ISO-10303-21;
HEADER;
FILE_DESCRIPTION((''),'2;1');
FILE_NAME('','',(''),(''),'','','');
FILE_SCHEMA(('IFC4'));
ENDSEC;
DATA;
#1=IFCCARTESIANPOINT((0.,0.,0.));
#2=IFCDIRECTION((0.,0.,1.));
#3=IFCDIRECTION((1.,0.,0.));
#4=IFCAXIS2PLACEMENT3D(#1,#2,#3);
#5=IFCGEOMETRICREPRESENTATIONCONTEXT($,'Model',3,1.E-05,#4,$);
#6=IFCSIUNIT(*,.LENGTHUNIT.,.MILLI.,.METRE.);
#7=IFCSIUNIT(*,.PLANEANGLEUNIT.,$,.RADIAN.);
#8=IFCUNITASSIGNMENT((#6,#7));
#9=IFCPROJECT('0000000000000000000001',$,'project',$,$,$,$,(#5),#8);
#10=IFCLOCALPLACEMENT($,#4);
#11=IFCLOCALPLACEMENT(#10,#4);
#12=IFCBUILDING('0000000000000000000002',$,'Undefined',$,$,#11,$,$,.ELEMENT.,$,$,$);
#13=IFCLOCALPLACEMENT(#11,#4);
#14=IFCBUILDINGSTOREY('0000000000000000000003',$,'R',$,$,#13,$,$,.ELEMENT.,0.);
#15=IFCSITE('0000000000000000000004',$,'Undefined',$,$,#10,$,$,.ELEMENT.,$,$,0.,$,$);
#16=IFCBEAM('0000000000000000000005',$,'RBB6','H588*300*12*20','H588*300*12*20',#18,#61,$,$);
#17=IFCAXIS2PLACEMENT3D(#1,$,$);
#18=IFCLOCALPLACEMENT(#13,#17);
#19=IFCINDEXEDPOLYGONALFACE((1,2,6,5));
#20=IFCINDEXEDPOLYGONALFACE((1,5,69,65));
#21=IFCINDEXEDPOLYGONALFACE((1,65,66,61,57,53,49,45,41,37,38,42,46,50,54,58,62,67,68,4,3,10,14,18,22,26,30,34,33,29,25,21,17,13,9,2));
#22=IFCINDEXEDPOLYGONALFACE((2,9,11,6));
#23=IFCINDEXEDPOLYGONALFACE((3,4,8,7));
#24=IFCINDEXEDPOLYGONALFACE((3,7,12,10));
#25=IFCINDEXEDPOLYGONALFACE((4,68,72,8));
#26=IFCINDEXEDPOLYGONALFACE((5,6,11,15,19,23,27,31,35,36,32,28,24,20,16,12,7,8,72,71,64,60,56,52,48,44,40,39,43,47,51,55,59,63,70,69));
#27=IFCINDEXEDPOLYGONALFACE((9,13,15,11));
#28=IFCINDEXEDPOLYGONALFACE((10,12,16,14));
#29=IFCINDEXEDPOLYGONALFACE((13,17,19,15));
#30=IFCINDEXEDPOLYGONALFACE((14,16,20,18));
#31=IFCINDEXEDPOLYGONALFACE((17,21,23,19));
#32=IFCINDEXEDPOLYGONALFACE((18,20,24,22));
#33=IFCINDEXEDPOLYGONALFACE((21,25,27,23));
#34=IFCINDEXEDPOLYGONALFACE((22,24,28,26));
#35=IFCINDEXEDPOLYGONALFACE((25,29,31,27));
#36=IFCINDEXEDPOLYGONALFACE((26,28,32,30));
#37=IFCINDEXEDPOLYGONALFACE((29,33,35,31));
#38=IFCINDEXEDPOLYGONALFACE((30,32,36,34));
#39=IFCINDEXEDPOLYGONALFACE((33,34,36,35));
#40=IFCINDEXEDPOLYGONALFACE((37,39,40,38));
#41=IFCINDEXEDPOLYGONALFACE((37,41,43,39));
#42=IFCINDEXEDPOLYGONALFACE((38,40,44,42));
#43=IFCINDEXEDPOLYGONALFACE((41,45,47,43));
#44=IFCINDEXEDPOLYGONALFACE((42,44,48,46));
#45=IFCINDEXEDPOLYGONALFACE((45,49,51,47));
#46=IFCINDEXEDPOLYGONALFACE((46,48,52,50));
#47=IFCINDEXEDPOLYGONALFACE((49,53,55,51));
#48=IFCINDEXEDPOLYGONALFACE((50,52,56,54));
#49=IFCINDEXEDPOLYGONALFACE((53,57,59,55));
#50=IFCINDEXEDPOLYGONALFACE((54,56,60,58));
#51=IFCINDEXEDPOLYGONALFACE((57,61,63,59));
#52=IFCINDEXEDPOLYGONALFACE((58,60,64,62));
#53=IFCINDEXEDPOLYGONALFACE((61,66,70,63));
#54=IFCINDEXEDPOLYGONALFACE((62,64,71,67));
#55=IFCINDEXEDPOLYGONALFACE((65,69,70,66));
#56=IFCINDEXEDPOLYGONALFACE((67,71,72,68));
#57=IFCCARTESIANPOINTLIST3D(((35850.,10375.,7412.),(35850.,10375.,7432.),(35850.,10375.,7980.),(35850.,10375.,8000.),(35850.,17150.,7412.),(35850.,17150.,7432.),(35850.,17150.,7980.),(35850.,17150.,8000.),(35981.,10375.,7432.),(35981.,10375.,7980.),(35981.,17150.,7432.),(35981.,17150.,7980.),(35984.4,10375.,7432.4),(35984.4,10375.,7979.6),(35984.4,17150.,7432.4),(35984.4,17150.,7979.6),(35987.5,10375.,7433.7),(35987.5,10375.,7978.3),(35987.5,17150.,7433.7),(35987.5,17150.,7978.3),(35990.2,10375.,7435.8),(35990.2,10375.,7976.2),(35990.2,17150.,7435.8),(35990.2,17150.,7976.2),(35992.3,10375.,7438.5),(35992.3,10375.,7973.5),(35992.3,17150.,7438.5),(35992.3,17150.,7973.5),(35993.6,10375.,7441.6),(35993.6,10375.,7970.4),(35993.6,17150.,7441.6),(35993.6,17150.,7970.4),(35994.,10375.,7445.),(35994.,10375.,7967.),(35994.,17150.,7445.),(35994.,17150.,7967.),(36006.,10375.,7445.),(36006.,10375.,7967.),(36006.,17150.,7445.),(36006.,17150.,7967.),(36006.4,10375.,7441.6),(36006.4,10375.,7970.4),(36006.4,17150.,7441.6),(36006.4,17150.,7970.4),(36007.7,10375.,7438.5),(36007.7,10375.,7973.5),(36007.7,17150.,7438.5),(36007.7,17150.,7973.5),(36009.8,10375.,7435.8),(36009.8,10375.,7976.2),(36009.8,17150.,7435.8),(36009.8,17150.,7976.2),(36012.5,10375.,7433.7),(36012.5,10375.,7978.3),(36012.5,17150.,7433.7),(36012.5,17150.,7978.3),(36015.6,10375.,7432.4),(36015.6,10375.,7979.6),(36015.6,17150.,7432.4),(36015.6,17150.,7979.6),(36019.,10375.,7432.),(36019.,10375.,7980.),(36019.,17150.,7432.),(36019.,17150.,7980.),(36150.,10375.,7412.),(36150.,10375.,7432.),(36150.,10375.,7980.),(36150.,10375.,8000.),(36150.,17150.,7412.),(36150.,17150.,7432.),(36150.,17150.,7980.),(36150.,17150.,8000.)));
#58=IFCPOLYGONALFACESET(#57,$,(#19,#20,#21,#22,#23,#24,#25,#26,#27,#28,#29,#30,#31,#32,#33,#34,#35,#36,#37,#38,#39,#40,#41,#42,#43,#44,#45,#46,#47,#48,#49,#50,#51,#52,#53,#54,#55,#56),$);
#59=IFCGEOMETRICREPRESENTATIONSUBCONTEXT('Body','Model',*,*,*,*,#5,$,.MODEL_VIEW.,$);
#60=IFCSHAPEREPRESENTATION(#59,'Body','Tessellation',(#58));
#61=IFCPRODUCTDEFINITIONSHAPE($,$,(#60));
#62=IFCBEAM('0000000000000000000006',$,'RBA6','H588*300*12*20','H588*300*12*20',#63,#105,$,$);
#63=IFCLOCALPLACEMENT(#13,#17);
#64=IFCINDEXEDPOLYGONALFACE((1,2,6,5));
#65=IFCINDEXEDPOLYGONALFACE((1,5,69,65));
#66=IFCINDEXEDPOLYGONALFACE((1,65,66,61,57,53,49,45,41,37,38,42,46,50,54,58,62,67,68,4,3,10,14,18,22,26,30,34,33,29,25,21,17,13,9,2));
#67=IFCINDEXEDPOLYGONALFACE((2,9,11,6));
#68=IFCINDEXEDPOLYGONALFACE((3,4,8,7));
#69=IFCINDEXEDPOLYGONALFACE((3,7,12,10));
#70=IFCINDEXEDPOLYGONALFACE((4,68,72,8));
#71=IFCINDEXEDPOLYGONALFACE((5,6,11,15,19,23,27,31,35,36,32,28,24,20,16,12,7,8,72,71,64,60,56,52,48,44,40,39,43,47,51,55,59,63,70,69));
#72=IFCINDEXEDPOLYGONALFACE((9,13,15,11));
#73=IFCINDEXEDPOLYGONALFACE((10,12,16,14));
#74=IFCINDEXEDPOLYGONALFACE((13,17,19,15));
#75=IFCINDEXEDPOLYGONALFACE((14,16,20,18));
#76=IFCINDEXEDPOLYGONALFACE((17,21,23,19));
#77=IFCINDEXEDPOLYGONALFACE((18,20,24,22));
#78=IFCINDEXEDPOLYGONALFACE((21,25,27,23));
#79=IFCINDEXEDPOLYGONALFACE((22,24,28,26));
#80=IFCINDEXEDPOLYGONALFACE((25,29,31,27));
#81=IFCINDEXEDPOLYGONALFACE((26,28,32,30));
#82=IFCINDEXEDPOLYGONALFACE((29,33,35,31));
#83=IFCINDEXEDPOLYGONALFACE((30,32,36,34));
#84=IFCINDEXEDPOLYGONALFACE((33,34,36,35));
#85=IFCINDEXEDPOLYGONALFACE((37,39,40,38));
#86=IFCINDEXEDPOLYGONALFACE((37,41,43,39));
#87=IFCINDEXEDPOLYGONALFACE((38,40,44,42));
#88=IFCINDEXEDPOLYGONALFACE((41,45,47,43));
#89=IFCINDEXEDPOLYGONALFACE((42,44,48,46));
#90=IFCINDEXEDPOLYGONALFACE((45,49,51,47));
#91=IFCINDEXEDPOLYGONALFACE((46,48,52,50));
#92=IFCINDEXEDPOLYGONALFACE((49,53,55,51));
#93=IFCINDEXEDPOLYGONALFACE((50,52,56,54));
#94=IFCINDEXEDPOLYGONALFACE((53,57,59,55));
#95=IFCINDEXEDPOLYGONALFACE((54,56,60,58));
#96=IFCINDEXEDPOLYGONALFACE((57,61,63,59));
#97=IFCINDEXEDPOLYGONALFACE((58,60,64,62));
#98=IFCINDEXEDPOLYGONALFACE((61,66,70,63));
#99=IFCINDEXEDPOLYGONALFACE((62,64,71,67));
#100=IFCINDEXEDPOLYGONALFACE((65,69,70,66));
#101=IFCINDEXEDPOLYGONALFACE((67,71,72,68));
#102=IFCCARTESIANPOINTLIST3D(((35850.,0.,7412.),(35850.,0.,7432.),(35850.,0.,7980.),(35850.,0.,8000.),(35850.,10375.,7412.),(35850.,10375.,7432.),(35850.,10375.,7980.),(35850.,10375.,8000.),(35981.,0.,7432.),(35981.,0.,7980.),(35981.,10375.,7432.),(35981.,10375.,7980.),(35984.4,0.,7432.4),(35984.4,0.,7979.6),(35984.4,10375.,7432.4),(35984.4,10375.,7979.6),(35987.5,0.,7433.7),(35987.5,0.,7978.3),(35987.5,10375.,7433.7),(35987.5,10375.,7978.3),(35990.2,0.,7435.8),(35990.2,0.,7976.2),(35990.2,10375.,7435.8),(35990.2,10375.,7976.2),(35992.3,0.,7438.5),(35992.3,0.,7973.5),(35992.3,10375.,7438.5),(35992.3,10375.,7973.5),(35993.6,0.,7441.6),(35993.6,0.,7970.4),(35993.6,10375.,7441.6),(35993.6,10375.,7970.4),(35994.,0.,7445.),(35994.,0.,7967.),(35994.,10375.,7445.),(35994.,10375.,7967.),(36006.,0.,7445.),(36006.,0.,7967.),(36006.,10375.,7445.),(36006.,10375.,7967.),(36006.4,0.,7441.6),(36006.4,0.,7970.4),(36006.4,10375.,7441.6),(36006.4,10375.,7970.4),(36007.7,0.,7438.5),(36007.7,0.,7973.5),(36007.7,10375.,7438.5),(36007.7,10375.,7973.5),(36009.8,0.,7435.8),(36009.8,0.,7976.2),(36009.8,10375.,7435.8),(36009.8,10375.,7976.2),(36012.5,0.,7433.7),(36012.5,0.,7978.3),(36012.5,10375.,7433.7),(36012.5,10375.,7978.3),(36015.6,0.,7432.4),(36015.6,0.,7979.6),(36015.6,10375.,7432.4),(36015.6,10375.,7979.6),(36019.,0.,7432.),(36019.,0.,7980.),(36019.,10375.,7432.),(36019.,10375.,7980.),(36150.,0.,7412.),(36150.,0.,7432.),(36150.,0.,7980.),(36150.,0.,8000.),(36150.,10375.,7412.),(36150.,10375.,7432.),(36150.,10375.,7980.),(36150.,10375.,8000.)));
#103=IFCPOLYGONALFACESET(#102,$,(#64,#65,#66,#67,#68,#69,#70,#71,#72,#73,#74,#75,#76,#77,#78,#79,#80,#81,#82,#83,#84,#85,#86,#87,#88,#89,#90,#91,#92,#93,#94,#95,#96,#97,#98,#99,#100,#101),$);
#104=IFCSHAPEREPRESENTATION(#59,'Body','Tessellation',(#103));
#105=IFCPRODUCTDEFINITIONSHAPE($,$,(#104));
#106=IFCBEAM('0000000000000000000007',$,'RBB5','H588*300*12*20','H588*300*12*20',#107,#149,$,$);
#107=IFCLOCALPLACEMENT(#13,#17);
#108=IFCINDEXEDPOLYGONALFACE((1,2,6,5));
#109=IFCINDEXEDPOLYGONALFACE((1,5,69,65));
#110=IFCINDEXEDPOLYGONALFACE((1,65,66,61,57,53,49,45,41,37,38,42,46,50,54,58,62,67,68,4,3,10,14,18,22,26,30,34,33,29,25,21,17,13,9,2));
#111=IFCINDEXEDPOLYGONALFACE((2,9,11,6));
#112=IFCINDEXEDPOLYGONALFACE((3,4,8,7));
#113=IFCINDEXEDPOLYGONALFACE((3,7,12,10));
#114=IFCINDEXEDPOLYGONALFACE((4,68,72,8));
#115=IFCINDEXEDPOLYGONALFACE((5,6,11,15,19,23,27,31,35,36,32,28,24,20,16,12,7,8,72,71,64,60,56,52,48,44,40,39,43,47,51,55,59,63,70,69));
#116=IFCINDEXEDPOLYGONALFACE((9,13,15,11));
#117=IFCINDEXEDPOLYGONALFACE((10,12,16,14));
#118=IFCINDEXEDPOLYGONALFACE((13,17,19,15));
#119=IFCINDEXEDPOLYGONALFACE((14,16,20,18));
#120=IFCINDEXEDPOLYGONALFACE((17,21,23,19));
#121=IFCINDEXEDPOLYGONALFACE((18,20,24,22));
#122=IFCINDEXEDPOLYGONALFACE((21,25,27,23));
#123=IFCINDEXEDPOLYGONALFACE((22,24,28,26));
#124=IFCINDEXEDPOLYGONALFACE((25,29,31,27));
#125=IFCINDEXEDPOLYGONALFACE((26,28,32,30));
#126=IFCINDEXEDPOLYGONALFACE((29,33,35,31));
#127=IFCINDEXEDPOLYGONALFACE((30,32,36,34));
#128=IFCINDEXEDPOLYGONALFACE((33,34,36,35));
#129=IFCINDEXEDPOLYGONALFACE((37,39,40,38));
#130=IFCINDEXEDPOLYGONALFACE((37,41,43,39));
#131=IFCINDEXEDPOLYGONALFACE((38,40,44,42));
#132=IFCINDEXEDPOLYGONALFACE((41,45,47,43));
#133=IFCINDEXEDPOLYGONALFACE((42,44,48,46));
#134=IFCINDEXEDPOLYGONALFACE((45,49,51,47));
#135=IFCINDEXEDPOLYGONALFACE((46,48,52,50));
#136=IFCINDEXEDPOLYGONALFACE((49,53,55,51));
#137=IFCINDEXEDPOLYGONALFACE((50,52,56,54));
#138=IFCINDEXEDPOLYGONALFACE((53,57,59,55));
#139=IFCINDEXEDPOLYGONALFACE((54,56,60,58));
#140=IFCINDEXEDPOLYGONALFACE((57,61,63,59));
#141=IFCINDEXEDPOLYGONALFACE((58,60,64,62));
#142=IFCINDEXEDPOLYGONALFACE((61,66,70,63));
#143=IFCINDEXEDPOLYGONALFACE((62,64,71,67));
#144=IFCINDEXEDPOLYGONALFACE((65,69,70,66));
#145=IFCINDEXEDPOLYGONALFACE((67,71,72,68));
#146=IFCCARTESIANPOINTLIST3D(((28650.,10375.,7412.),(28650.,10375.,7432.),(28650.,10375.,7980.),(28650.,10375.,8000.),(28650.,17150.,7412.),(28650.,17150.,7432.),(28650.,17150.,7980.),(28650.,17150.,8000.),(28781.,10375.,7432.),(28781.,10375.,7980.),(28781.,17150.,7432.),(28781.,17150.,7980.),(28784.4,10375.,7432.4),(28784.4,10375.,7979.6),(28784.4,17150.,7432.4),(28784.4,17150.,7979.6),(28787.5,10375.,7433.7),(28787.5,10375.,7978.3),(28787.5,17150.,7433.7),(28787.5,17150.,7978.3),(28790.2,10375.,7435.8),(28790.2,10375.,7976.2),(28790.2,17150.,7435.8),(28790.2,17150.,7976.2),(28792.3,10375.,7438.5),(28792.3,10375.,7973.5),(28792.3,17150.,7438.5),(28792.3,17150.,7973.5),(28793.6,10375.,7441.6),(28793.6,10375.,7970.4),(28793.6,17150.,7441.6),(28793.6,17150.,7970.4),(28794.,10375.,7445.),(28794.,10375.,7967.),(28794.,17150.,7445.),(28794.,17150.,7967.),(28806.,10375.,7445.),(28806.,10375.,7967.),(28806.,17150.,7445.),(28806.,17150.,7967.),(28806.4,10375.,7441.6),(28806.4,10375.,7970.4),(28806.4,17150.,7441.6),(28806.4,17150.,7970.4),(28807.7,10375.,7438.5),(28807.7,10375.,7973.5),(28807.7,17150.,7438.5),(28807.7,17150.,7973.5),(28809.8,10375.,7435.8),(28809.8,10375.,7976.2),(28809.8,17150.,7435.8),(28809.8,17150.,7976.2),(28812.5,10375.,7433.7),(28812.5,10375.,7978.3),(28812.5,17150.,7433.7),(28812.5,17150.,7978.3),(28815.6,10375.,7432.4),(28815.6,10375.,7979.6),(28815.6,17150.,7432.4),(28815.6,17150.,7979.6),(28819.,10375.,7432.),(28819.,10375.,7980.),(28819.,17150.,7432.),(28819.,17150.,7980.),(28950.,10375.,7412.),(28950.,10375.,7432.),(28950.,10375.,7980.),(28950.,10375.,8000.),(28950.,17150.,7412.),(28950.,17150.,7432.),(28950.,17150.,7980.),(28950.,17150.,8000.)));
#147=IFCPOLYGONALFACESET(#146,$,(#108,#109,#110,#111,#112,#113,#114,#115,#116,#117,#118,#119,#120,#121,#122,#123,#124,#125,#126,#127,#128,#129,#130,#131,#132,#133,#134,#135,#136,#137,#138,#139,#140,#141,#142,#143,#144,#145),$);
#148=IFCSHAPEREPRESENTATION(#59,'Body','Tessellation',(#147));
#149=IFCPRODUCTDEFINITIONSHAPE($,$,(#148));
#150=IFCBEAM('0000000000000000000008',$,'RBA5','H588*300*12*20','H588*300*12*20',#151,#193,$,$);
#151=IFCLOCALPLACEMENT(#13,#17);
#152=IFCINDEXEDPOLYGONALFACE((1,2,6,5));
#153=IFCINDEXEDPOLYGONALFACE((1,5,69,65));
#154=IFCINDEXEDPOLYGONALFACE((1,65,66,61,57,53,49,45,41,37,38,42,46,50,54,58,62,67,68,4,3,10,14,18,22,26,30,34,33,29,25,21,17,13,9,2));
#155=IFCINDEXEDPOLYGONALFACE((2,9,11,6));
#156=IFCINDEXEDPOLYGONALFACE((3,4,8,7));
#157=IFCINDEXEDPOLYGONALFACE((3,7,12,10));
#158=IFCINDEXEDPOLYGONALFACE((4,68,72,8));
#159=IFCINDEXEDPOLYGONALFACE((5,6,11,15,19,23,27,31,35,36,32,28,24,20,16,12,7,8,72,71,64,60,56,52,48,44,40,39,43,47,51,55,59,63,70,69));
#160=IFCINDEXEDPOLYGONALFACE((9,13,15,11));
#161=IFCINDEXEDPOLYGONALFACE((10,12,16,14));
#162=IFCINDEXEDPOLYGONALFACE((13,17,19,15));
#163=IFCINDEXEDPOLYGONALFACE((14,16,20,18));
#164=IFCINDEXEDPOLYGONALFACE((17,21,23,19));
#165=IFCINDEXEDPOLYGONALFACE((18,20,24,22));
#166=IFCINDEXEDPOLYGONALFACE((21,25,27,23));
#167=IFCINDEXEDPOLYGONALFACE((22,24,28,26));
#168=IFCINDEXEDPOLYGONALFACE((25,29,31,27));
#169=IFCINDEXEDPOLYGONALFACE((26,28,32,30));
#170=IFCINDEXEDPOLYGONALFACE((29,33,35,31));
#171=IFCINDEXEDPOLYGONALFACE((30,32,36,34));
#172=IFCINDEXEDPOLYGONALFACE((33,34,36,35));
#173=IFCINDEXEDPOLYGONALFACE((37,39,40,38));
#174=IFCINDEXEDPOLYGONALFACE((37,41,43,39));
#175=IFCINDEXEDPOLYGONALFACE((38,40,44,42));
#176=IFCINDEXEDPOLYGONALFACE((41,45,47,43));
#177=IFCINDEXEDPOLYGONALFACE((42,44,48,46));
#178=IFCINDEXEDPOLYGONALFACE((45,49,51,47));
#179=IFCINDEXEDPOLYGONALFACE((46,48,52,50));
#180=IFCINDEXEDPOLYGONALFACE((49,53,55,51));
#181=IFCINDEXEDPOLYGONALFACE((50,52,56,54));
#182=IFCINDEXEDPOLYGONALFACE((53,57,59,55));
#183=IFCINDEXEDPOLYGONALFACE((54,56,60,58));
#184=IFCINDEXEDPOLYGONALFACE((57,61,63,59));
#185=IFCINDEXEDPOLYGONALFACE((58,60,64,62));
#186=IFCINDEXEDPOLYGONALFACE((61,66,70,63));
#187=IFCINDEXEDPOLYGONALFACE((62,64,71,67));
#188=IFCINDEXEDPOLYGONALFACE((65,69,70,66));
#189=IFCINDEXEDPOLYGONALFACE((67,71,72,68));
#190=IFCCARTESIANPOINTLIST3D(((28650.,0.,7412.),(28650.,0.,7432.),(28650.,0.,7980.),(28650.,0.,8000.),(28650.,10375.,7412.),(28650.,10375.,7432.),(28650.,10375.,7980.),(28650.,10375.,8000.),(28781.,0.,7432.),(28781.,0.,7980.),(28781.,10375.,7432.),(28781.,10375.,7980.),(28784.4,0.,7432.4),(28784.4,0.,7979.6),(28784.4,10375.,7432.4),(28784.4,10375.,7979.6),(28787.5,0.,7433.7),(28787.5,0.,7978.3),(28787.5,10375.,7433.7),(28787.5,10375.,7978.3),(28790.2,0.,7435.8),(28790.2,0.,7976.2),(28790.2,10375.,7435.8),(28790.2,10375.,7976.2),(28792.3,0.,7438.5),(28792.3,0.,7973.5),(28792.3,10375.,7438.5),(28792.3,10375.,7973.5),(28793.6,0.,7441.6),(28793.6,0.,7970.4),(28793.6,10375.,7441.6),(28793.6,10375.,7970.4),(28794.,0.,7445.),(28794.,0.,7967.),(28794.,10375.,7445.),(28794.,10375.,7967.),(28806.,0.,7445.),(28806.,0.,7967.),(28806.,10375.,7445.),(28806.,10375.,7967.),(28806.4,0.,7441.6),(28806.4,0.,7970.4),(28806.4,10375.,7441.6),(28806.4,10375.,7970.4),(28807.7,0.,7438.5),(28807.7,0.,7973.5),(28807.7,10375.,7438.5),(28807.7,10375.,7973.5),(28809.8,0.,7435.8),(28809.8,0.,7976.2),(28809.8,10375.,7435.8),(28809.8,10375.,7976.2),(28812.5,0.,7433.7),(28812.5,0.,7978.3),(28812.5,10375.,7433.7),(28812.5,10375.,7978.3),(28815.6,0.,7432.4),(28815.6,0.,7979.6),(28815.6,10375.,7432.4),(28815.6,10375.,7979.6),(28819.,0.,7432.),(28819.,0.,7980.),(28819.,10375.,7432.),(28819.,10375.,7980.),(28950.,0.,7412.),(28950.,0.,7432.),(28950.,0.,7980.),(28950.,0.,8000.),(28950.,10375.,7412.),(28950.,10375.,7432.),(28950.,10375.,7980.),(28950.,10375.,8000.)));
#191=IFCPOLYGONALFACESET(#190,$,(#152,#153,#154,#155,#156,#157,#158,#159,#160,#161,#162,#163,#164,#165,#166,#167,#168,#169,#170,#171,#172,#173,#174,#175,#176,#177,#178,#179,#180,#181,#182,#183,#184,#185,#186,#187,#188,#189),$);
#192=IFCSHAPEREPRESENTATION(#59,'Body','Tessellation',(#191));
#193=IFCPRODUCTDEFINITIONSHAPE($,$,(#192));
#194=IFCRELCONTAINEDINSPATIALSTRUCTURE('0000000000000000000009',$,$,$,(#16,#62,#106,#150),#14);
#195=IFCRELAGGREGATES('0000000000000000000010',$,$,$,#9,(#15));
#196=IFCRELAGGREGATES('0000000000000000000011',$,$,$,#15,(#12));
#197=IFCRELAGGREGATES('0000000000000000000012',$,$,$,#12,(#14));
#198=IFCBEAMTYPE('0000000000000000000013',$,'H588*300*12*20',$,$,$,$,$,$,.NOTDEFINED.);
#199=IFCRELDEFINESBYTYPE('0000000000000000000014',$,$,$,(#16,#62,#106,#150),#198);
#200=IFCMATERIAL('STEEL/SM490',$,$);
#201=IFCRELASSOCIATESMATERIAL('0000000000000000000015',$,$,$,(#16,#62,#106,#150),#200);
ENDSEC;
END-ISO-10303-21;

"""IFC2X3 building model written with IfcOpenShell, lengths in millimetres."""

from ifc_helpers import new_model, si_unit, frame, origin_with_axes, origin_2d_with_axis, place, context, subcontext, project, spatial, i_section, extrude, material, type_object, element, save


model = new_model("IFC2X3")

# Units and contexts
model_context = context("Model", 3, precision=1e-05, world=origin_with_axes())
body_context = subcontext(model_context, "Body", "Model", "MODEL_VIEW")
ifc_project = project(units=[si_unit("LENGTHUNIT", "METRE", prefix="MILLI"), si_unit("PLANEANGLEUNIT", "RADIAN")], contexts=[model_context])

# Site, building, storey
site_placement = place(None, origin_with_axes())
site = spatial("IfcSite", under=ifc_project, at=site_placement, Name="Undefined", CompositionType="ELEMENT", RefElevation=0.0)
building_placement = place(site_placement, origin_with_axes())
building = spatial("IfcBuilding", under=site, at=building_placement, Name="Undefined", CompositionType="ELEMENT")
storey_placement = place(building_placement, origin_with_axes())
storey = spatial("IfcBuildingStorey", under=building, at=storey_placement, Name="R", CompositionType="ELEMENT", Elevation=0.0)

# Beams
ifc_material_1 = material(Name="STEEL/SM490")
beam_type_1 = type_object("IfcBeamType", Name="H588*300*12*20", PredefinedType="NOTDEFINED")
beam_1_placement = place(storey_placement, frame((36000.0, 10375.0, 7706.0), z_axis=(0.0, 0.0, 1.0), x_axis=(0.0, 1.0, 0.0)))
element("IfcBeam", 1, at=beam_1_placement, inside=storey, type_object=beam_type_1, material=ifc_material_1, Name="RBB6", Description="H588*300*12*20", ObjectType="H588*300*12*20", context=body_context, shape_type="SweptSolid", body=[
    extrude(i_section(OverallWidth=300.0, OverallDepth=588.0, WebThickness=12.0, FlangeThickness=20.0, FilletRadius=13.0, at=origin_2d_with_axis()), frame((6775.0, 0.0, 0.0), z_axis=(-1.0, 0.0, 0.0), x_axis=(0.0, -1.0, 0.0)), (0.0, 0.0, 1.0), 6775.0),
])
beam_2_placement = place(storey_placement, frame((36000.0, 0.0, 7706.0), z_axis=(0.0, 0.0, 1.0), x_axis=(0.0, 1.0, 0.0)))
element("IfcBeam", 2, at=beam_2_placement, inside=storey, type_object=beam_type_1, material=ifc_material_1, Name="RBA6", Description="H588*300*12*20", ObjectType="H588*300*12*20", context=body_context, shape_type="SweptSolid", body=[
    extrude(i_section(OverallWidth=300.0, OverallDepth=588.0, WebThickness=12.0, FlangeThickness=20.0, FilletRadius=13.0, at=origin_2d_with_axis()), frame((10375.0, 0.0, 0.0), z_axis=(-1.0, 0.0, 0.0), x_axis=(0.0, -1.0, 0.0)), (0.0, 0.0, 1.0), 10375.0),
])
beam_3_placement = place(storey_placement, frame((28800.0, 10375.0, 7706.0), z_axis=(0.0, 0.0, 1.0), x_axis=(0.0, 1.0, 0.0)))
element("IfcBeam", 3, at=beam_3_placement, inside=storey, type_object=beam_type_1, material=ifc_material_1, Name="RBB5", Description="H588*300*12*20", ObjectType="H588*300*12*20", context=body_context, shape_type="SweptSolid", body=[
    extrude(i_section(OverallWidth=300.0, OverallDepth=588.0, WebThickness=12.0, FlangeThickness=20.0, FilletRadius=13.0, at=origin_2d_with_axis()), frame((6775.0, 0.0, 0.0), z_axis=(-1.0, 0.0, 0.0), x_axis=(0.0, -1.0, 0.0)), (0.0, 0.0, 1.0), 6775.0),
])
beam_4_placement = place(storey_placement, frame((28800.0, 0.0, 7706.0), z_axis=(0.0, 0.0, 1.0), x_axis=(0.0, 1.0, 0.0)))
element("IfcBeam", 4, at=beam_4_placement, inside=storey, type_object=beam_type_1, material=ifc_material_1, Name="RBA5", Description="H588*300*12*20", ObjectType="H588*300*12*20", context=body_context, shape_type="SweptSolid", body=[
    extrude(i_section(OverallWidth=300.0, OverallDepth=588.0, WebThickness=12.0, FlangeThickness=20.0, FilletRadius=13.0, at=origin_2d_with_axis()), frame((10375.0, 0.0, 0.0), z_axis=(-1.0, 0.0, 0.0), x_axis=(0.0, -1.0, 0.0)), (0.0, 0.0, 1.0), 10375.0),
])

save(model, "model.ifc")
